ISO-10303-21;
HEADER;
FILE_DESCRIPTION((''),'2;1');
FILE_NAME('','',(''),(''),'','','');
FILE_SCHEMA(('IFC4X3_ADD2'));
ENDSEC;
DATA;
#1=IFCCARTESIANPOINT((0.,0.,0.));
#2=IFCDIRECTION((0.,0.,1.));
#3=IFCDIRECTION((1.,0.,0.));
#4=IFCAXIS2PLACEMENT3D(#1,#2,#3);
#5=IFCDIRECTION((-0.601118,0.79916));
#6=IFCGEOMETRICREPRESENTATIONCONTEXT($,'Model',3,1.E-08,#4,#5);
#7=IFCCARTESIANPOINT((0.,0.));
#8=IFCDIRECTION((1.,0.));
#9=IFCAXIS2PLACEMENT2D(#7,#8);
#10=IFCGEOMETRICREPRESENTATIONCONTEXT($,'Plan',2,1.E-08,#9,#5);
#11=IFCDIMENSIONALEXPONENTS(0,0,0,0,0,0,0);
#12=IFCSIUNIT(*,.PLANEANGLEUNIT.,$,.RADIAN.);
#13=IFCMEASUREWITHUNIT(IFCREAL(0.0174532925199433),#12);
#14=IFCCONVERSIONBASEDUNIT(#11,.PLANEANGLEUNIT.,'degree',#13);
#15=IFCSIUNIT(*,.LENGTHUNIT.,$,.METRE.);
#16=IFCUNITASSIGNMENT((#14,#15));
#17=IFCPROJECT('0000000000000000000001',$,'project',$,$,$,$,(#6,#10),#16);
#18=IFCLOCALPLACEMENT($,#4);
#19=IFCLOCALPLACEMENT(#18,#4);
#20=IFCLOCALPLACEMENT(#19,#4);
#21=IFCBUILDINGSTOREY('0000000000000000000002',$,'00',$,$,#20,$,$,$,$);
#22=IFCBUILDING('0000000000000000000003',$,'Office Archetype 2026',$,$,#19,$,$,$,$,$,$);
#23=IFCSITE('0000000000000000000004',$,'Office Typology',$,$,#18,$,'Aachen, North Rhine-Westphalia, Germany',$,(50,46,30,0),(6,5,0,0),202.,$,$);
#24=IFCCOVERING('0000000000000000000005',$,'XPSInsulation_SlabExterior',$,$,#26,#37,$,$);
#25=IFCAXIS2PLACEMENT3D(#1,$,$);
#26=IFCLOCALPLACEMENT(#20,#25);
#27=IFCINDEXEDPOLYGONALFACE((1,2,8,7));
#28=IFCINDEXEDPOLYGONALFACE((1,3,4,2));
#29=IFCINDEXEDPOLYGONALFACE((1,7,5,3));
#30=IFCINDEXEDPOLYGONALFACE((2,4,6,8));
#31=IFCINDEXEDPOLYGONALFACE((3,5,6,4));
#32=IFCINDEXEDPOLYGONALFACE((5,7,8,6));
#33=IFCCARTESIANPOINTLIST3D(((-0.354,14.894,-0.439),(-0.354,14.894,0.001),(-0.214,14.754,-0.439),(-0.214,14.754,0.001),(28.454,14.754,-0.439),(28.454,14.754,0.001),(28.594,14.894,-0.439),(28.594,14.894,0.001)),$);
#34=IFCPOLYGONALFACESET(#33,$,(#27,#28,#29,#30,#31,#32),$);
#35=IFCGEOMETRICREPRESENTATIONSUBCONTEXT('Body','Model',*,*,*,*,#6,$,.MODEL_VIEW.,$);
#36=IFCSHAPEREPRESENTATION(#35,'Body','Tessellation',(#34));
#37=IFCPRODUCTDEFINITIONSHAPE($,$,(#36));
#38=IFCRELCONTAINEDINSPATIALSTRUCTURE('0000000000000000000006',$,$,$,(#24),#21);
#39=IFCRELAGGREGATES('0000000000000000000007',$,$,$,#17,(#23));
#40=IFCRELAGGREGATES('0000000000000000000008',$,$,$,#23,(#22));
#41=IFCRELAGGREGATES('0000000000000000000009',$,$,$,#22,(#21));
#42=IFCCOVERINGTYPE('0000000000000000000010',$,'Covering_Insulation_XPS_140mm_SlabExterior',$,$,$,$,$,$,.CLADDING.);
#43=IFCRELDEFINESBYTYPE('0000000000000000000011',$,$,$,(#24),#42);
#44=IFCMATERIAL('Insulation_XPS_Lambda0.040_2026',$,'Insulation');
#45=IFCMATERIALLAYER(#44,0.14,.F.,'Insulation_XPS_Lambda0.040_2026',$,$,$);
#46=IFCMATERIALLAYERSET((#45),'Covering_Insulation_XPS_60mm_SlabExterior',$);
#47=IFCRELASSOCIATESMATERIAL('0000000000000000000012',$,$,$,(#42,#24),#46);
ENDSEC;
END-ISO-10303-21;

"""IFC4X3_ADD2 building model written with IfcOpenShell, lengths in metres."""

from ifc_helpers import new_model, entity, si_unit, converted_unit, direction, frame, origin_with_axes, origin_2d_with_axis, place, context, subcontext, project, spatial, line, indexed_curve, outline, extrude, material, layer, layer_set, layer_usage, type_object, element, save


model = new_model("IFC4X3_ADD2")

# Units and contexts
model_context = context("Model", 3, precision=1e-08, world=origin_with_axes(), true_north=direction((-0.601118, 0.79916)))
plan_context = context("Plan", 2, precision=1e-08, world=origin_2d_with_axis(), true_north=direction((-0.601118, 0.79916)))
body_context = subcontext(model_context, "Body", "Model", "MODEL_VIEW")
ifc_project = project(units=[converted_unit("PLANEANGLEUNIT", "degree", entity("IfcReal", 0.0174532925199433), si_unit("PLANEANGLEUNIT", "RADIAN"), dimensions=[0, 0, 0, 0, 0, 0, 0]), si_unit("LENGTHUNIT", "METRE")], contexts=[model_context, plan_context])

# Site, building, storey
site_placement = place(None, origin_with_axes())
site = spatial("IfcSite", under=ifc_project, at=site_placement, Name="Office Typology", LongName="Aachen, North Rhine-Westphalia, Germany", RefLatitude=(50, 46, 30, 0), RefLongitude=(6, 5, 0, 0), RefElevation=202.0)
building_placement = place(site_placement, origin_with_axes())
building = spatial("IfcBuilding", under=site, at=building_placement, Name="Office Archetype 2026")
storey_placement = place(building_placement, origin_with_axes())
storey = spatial("IfcBuildingStorey", under=building, at=storey_placement, Name="00")

# Covering
ifc_material_1 = material(Name="Insulation_XPS_Lambda0.040_2026", Category="Insulation")
ifc_layer_1 = layer(ifc_material_1, 0.14, ventilated=False, Name="Insulation_XPS_Lambda0.040_2026")
ifc_layer_set_1 = layer_set([ifc_layer_1], Name="Covering_Insulation_XPS_60mm_SlabExterior")
ifc_layer_usage_1 = layer_usage(ifc_layer_set_1, "AXIS2", "POSITIVE", 0.0)
covering_type = type_object("IfcCoveringType", Name="Covering_Insulation_XPS_140mm_SlabExterior", PredefinedType="CLADDING", material=ifc_layer_set_1)
covering_placement = place(storey_placement, frame((28.594, 14.894, -0.439), z_axis=(0.0, 0.0, 1.0), x_axis=(-1.0, 0.0, 0.0)))
element("IfcCovering", 1, at=covering_placement, inside=storey, type_object=covering_type, material=ifc_layer_usage_1, Name="XPSInsulation_SlabExterior", context=body_context, shape_type="SweptSolid", body=[
    extrude(outline(indexed_curve([(0.0, 0.0), (0.14, 0.14), (28.808, 0.14), (28.948, 0.0)], segments=[line(1, 2, 3, 4, 1)])), origin_with_axes(), (0.0, 0.0, 1.0), 0.44),
])

save(model, "model.ifc")
